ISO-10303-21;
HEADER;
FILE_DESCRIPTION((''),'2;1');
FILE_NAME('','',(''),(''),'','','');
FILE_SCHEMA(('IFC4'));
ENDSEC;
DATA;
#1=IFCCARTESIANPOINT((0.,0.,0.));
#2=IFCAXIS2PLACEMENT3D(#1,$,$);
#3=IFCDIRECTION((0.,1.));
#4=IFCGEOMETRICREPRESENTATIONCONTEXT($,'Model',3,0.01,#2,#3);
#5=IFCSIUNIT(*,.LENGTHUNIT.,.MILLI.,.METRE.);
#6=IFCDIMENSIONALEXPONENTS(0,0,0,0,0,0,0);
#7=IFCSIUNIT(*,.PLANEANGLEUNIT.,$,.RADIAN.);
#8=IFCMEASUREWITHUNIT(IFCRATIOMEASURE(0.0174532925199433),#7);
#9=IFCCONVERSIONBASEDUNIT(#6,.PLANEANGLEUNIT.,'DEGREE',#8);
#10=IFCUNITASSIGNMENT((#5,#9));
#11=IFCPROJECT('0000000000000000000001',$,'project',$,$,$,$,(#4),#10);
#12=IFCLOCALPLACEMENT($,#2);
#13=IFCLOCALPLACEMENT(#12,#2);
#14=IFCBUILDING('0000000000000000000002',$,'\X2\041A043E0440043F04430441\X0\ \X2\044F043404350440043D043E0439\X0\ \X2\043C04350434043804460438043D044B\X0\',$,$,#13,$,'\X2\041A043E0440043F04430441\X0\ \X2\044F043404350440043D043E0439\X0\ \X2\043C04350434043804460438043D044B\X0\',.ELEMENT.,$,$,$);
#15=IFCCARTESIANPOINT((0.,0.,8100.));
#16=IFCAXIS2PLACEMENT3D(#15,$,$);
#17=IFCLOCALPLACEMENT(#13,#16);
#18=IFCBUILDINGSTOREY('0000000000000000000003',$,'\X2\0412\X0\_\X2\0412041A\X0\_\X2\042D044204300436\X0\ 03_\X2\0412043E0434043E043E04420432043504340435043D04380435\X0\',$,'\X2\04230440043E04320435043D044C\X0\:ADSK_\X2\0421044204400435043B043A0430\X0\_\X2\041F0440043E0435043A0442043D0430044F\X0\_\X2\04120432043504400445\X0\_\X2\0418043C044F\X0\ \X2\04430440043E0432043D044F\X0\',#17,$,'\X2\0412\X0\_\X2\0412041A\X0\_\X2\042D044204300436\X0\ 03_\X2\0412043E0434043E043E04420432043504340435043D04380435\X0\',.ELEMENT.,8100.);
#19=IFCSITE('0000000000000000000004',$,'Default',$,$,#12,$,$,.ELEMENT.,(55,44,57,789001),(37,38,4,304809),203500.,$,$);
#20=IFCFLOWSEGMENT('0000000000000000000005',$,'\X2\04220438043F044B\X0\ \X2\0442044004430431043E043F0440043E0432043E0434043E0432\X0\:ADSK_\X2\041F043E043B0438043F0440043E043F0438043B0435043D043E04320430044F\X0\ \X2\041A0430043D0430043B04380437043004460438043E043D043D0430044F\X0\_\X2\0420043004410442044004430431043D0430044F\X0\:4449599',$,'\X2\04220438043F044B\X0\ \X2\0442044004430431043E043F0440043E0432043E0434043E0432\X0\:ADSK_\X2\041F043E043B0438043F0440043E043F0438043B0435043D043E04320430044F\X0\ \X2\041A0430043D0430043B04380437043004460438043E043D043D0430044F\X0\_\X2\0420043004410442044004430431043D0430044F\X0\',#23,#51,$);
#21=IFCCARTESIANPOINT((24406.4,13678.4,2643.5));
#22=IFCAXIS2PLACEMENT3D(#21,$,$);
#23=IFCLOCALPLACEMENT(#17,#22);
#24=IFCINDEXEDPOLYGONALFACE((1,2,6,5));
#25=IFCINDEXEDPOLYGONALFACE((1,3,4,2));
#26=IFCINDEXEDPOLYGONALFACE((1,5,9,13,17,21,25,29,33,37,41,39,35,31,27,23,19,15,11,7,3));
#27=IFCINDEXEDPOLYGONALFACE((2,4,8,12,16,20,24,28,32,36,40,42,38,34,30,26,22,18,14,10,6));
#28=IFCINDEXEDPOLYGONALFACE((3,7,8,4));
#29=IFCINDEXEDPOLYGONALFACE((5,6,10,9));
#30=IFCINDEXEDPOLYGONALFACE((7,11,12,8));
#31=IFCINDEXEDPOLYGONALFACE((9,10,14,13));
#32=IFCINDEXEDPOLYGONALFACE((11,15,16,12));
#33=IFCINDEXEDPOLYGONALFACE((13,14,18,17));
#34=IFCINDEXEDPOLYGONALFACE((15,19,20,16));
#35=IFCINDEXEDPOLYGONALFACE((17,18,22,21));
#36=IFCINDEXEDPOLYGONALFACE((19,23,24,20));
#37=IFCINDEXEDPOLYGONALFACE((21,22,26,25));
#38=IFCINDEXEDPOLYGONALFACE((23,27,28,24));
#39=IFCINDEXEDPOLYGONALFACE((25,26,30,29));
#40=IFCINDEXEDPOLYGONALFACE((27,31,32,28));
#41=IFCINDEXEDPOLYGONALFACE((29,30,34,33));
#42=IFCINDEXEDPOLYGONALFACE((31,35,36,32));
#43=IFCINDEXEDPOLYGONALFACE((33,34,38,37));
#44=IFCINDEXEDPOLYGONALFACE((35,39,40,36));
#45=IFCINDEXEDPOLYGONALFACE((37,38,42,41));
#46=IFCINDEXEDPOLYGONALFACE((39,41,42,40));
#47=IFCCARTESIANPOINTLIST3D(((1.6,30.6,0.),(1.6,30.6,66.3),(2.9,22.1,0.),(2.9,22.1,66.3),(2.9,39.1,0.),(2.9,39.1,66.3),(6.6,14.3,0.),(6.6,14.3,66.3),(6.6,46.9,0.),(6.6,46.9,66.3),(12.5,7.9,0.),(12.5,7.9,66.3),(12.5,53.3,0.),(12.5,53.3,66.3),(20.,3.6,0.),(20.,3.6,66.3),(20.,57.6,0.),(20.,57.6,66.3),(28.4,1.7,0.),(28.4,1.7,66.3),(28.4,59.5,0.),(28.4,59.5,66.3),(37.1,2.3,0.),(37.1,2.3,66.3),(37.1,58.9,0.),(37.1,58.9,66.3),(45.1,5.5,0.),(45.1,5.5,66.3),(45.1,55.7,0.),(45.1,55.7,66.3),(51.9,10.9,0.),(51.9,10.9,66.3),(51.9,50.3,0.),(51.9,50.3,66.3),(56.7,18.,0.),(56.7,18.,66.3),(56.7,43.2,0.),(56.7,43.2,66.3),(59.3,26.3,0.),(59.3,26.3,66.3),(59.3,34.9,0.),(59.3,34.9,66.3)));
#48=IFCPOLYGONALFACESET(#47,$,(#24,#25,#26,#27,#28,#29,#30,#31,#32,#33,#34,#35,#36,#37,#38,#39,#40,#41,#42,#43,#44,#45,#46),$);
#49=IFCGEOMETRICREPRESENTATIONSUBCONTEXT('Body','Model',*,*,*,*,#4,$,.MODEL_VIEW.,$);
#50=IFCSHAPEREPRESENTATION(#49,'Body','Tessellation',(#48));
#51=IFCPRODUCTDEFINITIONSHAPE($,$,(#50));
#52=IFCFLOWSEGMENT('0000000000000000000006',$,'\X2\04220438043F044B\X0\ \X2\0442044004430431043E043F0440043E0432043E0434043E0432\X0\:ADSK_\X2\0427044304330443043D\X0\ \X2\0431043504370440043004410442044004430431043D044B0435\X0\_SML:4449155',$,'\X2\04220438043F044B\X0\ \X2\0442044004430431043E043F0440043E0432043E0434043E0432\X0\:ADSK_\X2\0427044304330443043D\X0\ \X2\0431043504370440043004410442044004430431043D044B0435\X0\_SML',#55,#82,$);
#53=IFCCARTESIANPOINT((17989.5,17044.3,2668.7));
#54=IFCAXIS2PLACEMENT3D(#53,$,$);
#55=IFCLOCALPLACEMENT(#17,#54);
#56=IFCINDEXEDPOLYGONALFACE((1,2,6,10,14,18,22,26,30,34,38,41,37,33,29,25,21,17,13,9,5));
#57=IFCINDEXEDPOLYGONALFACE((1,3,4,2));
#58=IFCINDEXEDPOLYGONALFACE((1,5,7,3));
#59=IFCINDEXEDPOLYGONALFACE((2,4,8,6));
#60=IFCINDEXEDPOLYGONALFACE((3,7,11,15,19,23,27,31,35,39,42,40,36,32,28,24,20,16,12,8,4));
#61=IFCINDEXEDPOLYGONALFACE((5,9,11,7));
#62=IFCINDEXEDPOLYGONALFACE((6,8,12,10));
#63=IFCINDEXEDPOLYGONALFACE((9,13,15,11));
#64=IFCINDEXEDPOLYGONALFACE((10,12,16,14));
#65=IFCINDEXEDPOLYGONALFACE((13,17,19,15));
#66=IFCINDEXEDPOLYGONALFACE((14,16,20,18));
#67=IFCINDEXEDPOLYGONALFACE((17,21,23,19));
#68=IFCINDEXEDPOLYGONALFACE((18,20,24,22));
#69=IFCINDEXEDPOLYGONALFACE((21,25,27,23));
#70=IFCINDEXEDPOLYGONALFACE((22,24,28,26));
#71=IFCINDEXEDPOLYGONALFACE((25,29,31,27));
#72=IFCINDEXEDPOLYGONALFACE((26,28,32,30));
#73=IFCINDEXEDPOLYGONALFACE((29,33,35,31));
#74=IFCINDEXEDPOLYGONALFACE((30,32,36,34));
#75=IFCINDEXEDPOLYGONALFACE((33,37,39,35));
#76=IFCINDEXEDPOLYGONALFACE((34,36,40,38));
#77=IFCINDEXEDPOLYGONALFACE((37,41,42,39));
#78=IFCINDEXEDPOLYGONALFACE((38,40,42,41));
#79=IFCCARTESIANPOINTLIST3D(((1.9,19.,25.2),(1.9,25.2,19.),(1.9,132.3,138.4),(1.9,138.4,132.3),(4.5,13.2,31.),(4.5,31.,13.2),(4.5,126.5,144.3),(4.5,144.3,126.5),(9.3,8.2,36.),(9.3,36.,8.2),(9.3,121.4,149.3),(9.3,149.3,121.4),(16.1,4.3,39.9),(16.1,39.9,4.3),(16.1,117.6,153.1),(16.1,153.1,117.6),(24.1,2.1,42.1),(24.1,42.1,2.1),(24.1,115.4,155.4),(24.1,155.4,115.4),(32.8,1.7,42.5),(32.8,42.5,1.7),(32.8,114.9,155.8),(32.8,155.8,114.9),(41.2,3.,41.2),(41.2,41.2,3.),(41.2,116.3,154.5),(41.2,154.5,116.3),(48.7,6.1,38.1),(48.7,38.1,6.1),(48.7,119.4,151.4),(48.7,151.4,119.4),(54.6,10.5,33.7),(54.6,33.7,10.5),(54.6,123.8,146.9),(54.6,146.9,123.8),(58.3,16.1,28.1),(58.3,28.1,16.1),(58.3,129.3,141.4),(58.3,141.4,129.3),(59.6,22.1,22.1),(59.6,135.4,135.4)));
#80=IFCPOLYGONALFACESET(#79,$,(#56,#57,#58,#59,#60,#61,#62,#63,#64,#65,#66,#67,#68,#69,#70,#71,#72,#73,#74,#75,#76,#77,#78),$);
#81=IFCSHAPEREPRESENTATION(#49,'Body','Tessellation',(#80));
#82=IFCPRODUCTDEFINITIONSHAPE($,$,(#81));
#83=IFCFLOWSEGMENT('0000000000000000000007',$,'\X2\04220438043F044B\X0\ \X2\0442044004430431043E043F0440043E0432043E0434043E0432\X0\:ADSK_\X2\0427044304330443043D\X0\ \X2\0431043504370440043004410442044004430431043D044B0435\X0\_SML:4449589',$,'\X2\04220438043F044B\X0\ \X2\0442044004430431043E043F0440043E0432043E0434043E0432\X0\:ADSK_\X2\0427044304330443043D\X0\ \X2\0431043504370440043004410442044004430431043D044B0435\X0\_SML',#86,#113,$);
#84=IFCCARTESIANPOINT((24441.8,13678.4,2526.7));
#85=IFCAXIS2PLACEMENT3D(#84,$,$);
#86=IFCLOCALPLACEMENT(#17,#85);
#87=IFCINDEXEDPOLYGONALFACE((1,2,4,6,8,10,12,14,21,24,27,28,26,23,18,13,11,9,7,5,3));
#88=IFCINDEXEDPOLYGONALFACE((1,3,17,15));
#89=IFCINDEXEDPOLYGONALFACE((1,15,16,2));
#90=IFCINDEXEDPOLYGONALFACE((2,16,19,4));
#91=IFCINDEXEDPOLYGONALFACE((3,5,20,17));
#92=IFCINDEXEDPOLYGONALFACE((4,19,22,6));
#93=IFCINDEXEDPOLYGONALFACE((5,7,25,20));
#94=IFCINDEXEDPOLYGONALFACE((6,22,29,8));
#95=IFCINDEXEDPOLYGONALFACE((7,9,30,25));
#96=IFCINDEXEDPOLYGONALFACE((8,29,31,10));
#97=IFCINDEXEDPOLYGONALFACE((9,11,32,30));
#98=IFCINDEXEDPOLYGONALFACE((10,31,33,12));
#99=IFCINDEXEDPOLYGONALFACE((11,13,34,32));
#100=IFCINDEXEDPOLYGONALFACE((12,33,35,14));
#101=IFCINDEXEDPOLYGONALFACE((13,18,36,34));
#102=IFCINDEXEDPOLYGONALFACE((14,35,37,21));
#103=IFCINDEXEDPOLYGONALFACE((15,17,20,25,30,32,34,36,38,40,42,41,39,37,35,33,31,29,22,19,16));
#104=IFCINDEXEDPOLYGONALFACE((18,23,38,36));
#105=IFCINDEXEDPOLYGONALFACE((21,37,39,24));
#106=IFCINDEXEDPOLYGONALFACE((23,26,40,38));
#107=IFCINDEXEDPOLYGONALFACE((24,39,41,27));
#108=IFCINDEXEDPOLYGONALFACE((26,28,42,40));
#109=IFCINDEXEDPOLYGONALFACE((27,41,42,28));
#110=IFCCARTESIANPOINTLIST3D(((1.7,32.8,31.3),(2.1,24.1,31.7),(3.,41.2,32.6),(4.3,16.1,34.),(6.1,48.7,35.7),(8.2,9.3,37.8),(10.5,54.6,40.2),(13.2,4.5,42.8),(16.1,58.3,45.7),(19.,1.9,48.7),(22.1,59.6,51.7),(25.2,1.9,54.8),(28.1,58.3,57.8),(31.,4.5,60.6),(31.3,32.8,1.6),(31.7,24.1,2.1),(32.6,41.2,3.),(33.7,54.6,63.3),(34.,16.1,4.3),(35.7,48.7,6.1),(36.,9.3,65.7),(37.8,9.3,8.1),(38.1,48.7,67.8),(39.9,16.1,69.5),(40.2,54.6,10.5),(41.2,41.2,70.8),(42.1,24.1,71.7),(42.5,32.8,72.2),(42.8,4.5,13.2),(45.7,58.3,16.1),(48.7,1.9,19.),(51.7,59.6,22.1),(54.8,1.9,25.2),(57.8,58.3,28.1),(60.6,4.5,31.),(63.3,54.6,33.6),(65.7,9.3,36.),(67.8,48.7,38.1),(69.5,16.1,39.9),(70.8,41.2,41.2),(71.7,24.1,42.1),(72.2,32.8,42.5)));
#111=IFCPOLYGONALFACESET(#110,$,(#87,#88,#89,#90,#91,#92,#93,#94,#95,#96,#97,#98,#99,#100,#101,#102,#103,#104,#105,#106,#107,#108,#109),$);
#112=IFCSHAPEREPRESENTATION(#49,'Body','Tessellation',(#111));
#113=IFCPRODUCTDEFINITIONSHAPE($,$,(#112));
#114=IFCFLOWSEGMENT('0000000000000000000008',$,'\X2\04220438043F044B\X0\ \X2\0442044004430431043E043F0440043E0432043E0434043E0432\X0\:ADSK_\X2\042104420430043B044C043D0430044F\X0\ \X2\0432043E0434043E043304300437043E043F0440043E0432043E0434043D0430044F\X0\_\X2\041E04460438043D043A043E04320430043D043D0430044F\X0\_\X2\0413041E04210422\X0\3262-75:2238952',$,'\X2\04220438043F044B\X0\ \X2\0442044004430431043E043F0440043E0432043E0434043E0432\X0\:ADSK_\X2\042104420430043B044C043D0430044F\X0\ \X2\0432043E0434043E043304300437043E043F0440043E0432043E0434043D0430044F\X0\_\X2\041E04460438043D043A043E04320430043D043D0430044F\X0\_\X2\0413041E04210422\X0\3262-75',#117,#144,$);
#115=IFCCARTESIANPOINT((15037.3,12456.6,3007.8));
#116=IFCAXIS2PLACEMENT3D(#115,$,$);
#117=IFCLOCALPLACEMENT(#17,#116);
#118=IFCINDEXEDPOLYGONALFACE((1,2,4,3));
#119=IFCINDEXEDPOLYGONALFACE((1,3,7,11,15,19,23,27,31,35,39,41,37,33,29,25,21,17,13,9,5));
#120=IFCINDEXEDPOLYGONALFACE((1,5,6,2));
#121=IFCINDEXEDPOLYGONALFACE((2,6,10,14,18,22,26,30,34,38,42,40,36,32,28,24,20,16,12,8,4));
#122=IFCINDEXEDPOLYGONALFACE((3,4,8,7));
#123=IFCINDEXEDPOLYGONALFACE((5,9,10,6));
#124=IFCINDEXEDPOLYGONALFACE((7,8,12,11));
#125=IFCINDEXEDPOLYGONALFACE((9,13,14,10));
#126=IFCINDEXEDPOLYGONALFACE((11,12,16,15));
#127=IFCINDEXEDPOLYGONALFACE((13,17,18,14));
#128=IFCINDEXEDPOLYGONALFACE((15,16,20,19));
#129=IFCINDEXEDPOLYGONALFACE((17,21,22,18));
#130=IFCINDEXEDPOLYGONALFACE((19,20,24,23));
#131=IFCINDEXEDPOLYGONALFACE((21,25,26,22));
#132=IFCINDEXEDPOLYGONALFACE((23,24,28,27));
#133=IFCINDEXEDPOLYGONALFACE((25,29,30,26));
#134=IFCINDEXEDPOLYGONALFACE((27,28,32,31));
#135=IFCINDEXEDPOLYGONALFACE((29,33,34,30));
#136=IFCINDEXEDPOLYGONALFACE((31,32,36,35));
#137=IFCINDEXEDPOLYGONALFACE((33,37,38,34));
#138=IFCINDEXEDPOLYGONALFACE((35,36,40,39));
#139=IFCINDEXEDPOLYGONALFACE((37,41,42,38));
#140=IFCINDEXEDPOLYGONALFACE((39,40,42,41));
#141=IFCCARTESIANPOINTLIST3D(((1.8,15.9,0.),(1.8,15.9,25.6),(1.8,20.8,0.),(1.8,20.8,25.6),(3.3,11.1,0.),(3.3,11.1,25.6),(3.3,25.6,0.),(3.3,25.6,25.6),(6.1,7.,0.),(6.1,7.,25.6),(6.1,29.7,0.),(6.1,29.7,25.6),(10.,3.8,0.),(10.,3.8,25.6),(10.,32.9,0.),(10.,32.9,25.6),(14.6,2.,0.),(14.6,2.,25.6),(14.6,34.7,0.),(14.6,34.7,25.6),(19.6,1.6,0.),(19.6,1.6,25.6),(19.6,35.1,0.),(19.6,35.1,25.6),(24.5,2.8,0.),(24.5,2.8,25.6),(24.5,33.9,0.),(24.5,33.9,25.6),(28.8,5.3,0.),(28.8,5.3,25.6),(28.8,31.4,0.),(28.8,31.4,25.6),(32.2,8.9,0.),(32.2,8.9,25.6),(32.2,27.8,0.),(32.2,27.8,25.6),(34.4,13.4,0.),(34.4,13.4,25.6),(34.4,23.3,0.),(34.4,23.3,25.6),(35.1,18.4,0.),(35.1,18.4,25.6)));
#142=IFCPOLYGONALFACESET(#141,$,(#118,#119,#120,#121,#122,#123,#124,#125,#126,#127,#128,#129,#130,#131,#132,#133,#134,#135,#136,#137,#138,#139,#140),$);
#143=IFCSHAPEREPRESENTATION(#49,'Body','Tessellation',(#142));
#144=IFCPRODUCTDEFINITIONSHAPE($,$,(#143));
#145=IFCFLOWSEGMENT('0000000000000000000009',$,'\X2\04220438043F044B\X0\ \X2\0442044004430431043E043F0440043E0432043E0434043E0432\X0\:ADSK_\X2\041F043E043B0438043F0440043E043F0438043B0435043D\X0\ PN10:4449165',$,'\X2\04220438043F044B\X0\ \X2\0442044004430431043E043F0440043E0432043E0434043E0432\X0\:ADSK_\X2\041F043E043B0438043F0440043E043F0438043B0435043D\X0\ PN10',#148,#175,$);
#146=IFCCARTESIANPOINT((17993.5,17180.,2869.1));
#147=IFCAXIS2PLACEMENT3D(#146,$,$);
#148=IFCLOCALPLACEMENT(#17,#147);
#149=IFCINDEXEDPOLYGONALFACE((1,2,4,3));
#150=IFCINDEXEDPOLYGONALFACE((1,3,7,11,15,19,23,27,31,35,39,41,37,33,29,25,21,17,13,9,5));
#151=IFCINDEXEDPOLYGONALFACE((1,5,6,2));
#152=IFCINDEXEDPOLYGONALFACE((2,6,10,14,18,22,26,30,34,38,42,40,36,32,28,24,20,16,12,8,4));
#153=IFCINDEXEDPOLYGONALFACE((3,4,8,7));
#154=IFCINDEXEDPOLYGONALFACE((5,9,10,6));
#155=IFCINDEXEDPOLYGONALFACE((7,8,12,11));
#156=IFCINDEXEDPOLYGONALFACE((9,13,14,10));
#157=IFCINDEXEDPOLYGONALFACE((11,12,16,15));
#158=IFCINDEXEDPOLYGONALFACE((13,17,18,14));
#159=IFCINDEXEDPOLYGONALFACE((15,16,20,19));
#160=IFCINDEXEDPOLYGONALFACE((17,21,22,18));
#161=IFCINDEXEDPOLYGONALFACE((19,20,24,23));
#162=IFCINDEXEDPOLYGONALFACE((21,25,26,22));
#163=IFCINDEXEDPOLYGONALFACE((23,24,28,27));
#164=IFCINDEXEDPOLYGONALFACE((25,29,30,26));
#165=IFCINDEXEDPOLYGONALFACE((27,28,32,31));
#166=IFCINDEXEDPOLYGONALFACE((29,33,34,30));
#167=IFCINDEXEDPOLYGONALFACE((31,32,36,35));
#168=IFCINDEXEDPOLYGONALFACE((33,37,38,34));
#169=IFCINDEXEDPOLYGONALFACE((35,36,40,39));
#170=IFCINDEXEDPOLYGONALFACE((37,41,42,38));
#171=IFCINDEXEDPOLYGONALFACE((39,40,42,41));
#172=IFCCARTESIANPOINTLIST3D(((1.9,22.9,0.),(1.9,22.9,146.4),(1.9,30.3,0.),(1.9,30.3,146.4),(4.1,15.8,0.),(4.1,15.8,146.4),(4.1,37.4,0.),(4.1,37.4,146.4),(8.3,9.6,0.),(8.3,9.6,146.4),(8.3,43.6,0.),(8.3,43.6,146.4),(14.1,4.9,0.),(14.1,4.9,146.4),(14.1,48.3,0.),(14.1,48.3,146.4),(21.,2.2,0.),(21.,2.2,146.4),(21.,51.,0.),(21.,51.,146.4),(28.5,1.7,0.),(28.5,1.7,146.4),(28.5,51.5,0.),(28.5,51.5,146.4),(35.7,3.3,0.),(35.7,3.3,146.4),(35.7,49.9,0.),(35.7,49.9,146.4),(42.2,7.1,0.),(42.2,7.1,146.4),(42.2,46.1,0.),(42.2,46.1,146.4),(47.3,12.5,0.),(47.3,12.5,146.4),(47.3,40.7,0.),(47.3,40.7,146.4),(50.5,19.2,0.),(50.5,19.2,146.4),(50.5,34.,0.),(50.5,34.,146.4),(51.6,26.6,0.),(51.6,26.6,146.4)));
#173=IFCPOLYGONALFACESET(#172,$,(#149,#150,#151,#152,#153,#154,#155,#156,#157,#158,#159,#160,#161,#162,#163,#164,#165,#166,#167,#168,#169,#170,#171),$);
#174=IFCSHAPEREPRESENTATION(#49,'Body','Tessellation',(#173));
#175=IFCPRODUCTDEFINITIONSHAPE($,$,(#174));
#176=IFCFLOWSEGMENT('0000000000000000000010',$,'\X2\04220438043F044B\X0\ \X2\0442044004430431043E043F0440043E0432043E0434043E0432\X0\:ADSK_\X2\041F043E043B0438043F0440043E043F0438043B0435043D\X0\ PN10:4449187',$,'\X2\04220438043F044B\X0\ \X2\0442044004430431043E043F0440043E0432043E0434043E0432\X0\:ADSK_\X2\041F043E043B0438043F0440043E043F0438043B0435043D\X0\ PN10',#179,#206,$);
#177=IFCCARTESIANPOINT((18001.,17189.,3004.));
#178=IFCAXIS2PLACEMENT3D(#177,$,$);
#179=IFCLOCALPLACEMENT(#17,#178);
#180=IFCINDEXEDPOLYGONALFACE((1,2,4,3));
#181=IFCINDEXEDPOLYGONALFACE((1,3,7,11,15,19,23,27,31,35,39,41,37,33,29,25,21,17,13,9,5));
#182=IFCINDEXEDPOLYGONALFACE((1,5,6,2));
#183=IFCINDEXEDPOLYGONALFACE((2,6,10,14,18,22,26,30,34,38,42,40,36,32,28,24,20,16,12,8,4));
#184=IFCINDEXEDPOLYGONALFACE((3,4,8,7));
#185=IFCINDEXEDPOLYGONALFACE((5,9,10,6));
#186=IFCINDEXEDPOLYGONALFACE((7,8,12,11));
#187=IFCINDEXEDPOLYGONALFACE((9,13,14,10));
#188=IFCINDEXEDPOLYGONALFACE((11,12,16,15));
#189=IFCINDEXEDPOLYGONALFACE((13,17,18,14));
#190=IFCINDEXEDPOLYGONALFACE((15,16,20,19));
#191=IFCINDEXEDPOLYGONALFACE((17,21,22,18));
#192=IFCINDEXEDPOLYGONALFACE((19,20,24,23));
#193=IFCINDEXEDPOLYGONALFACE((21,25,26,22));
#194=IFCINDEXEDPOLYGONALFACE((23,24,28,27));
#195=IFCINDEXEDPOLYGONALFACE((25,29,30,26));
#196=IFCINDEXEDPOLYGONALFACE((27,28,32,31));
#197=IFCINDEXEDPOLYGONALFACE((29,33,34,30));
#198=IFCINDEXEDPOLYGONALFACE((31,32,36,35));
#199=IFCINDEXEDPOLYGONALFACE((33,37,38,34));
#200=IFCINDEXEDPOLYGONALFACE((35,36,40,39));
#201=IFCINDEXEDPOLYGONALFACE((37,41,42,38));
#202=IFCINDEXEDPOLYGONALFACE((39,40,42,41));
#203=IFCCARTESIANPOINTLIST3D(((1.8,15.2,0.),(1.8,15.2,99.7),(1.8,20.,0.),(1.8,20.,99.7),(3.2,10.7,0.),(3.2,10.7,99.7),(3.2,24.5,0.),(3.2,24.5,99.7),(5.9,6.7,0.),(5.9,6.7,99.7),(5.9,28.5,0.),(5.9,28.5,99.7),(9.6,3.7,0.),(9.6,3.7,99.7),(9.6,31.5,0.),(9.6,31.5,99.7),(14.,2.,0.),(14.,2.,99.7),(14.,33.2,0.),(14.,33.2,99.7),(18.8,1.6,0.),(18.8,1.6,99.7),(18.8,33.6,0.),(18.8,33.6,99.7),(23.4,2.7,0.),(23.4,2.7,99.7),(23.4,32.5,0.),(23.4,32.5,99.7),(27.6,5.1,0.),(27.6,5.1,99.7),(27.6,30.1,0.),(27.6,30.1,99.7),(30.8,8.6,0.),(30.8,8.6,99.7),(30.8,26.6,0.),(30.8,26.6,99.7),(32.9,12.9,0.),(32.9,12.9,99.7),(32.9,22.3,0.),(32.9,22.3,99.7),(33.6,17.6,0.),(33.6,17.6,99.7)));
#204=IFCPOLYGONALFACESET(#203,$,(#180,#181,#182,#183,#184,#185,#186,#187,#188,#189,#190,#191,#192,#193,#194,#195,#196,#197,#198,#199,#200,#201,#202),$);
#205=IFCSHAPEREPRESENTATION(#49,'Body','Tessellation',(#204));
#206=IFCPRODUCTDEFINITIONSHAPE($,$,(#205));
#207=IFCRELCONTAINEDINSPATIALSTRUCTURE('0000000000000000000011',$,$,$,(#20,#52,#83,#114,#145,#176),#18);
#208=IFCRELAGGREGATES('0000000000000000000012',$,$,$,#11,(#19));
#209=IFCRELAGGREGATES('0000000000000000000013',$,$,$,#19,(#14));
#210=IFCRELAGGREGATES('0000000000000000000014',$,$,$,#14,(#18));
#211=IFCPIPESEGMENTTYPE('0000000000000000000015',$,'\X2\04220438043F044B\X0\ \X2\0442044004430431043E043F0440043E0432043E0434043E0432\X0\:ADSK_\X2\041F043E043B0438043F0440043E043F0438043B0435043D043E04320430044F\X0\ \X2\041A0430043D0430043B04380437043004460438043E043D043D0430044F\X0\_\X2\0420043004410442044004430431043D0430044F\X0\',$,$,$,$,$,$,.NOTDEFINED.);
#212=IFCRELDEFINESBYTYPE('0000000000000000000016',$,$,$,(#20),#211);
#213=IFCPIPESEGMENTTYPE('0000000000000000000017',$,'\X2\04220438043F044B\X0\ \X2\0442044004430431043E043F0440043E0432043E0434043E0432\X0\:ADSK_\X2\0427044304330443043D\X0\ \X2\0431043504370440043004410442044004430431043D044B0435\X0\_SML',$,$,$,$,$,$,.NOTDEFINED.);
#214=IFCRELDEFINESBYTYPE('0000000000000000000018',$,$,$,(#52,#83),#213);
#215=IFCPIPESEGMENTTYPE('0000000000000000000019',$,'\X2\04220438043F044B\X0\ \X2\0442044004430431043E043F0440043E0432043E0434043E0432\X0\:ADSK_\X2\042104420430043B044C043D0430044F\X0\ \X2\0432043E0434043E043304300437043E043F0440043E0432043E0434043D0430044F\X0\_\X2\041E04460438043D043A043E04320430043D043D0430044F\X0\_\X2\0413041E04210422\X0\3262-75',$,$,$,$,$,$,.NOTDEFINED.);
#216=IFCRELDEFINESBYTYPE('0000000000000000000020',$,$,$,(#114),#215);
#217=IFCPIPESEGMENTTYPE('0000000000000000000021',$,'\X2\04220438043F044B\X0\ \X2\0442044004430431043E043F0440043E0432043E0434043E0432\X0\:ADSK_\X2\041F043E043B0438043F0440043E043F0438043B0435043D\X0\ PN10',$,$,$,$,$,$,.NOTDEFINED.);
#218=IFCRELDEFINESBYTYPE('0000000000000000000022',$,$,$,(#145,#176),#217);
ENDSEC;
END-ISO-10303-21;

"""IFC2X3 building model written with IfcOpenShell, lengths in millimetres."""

from ifc_helpers import new_model, entity, si_unit, converted_unit, direction, frame, origin, origin_2d_with_axis, place, context, subcontext, project, spatial, circle, extrude, type_object, element, save


model = new_model("IFC2X3")

# Units and contexts
model_context = context("Model", 3, precision=0.01, world=origin(), true_north=direction((0.0, 1.0)))
body_context = subcontext(model_context, "Body", "Model", "MODEL_VIEW")
ifc_project = project(units=[si_unit("LENGTHUNIT", "METRE", prefix="MILLI"), converted_unit("PLANEANGLEUNIT", "DEGREE", entity("IfcRatioMeasure", 0.0174532925199433), si_unit("PLANEANGLEUNIT", "RADIAN"), dimensions=[0, 0, 0, 0, 0, 0, 0])], contexts=[model_context])

# Site, building, storey
site_placement = place(None, origin())
site = spatial("IfcSite", under=ifc_project, at=site_placement, Name="Default", CompositionType="ELEMENT", RefLatitude=(55, 44, 57, 789001), RefLongitude=(37, 38, 4, 304809), RefElevation=203500.0)
building_placement = place(site_placement, origin())
building = spatial("IfcBuilding", under=site, at=building_placement, Name="Корпус ядерной медицины", LongName="Корпус ядерной медицины", CompositionType="ELEMENT")
storey_placement = place(building_placement, frame((0.0, 0.0, 8100.0)))
storey = spatial("IfcBuildingStorey", under=building, at=storey_placement, Name="В_ВК_Этаж 03_Водоотведение", ObjectType="Уровень:ADSK_Стрелка_Проектная_Вверх_Имя уровня", LongName="В_ВК_Этаж 03_Водоотведение", CompositionType="ELEMENT", Elevation=8100.0)

# Flow segments
pipe_segment_type_1 = type_object("IfcPipeSegmentType", Name="Типы трубопроводов:ADSK_Полипропиленовая Канализационная_Раструбная", PredefinedType="NOTDEFINED")
flow_segment_1_placement = place(storey_placement, frame((24406.4, 13678.4, 2643.5)))
element("IfcFlowSegment", 1, at=flow_segment_1_placement, inside=storey, type_object=pipe_segment_type_1, Name="Типы трубопроводов:ADSK_Полипропиленовая Канализационная_Раструбная:4449599", ObjectType="Типы трубопроводов:ADSK_Полипропиленовая Канализационная_Раструбная", context=body_context, shape_type="SweptSolid", body=[
    extrude(circle(Radius=29.0, at=origin_2d_with_axis()), frame((30.6, 30.6, 0.0), z_axis=(0.0, 0.0, 1.0), x_axis=(-1.0, 0.0, 0.0)), (0.0, 0.0, 1.0), 66.3),
])
pipe_segment_type_2 = type_object("IfcPipeSegmentType", Name="Типы трубопроводов:ADSK_Чугун безраструбные_SML", PredefinedType="NOTDEFINED")
flow_segment_2_placement = place(storey_placement, frame((17989.5, 17044.3, 2668.7)))
element("IfcFlowSegment", 2, at=flow_segment_2_placement, inside=storey, type_object=pipe_segment_type_2, Name="Типы трубопроводов:ADSK_Чугун безраструбные_SML:4449155", ObjectType="Типы трубопроводов:ADSK_Чугун безраструбные_SML", context=body_context, shape_type="SweptSolid", body=[
    extrude(circle(Radius=29.0, at=origin_2d_with_axis()), frame((30.6, 22.1, 22.1), z_axis=(0.0, 0.707107, 0.707107), x_axis=(1.0, 0.0, 0.0)), (0.0, 0.0, 1.0), 160.2),
])
flow_segment_3_placement = place(storey_placement, frame((24441.8, 13678.4, 2526.7)))
element("IfcFlowSegment", 3, at=flow_segment_3_placement, inside=storey, type_object=pipe_segment_type_2, Name="Типы трубопроводов:ADSK_Чугун безраструбные_SML:4449589", ObjectType="Типы трубопроводов:ADSK_Чугун безраструбные_SML", context=body_context, shape_type="SweptSolid", body=[
    extrude(circle(Radius=29.0, at=origin_2d_with_axis()), frame((22.1, 30.6, 51.7), z_axis=(0.707107, 0.0, -0.707107), x_axis=(0.0, 1.0, 0.0)), (0.0, 0.0, 1.0), 41.9),
])
pipe_segment_type_3 = type_object("IfcPipeSegmentType", Name="Типы трубопроводов:ADSK_Стальная водогазопроводная_Оцинкованная_ГОСТ3262-75", PredefinedType="NOTDEFINED")
flow_segment_4_placement = place(storey_placement, frame((15037.3, 12456.6, 3007.8)))
element("IfcFlowSegment", 4, at=flow_segment_4_placement, inside=storey, type_object=pipe_segment_type_3, Name="Типы трубопроводов:ADSK_Стальная водогазопроводная_Оцинкованная_ГОСТ3262-75:2238952", ObjectType="Типы трубопроводов:ADSK_Стальная водогазопроводная_Оцинкованная_ГОСТ3262-75", context=body_context, shape_type="SweptSolid", body=[
    extrude(circle(Radius=16.8, at=origin_2d_with_axis()), frame((18.4, 18.4, 0.0)), (0.0, 0.0, 1.0), 25.6),
])
pipe_segment_type_4 = type_object("IfcPipeSegmentType", Name="Типы трубопроводов:ADSK_Полипропилен PN10", PredefinedType="NOTDEFINED")
flow_segment_5_placement = place(storey_placement, frame((17993.5, 17180.0, 2869.1)))
element("IfcFlowSegment", 5, at=flow_segment_5_placement, inside=storey, type_object=pipe_segment_type_4, Name="Типы трубопроводов:ADSK_Полипропилен PN10:4449165", ObjectType="Типы трубопроводов:ADSK_Полипропилен PN10", context=body_context, shape_type="SweptSolid", body=[
    extrude(circle(Radius=25.0, at=origin_2d_with_axis()), frame((26.6, 26.6, 0.0)), (0.0, 0.0, 1.0), 146.4),
])
flow_segment_6_placement = place(storey_placement, frame((18001.0, 17189.0, 3004.0)))
element("IfcFlowSegment", 6, at=flow_segment_6_placement, inside=storey, type_object=pipe_segment_type_4, Name="Типы трубопроводов:ADSK_Полипропилен PN10:4449187", ObjectType="Типы трубопроводов:ADSK_Полипропилен PN10", context=body_context, shape_type="SweptSolid", body=[
    extrude(circle(Radius=16.0, at=origin_2d_with_axis()), frame((17.6, 17.6, 0.0)), (0.0, 0.0, 1.0), 99.7),
])

save(model, "model.ifc")
